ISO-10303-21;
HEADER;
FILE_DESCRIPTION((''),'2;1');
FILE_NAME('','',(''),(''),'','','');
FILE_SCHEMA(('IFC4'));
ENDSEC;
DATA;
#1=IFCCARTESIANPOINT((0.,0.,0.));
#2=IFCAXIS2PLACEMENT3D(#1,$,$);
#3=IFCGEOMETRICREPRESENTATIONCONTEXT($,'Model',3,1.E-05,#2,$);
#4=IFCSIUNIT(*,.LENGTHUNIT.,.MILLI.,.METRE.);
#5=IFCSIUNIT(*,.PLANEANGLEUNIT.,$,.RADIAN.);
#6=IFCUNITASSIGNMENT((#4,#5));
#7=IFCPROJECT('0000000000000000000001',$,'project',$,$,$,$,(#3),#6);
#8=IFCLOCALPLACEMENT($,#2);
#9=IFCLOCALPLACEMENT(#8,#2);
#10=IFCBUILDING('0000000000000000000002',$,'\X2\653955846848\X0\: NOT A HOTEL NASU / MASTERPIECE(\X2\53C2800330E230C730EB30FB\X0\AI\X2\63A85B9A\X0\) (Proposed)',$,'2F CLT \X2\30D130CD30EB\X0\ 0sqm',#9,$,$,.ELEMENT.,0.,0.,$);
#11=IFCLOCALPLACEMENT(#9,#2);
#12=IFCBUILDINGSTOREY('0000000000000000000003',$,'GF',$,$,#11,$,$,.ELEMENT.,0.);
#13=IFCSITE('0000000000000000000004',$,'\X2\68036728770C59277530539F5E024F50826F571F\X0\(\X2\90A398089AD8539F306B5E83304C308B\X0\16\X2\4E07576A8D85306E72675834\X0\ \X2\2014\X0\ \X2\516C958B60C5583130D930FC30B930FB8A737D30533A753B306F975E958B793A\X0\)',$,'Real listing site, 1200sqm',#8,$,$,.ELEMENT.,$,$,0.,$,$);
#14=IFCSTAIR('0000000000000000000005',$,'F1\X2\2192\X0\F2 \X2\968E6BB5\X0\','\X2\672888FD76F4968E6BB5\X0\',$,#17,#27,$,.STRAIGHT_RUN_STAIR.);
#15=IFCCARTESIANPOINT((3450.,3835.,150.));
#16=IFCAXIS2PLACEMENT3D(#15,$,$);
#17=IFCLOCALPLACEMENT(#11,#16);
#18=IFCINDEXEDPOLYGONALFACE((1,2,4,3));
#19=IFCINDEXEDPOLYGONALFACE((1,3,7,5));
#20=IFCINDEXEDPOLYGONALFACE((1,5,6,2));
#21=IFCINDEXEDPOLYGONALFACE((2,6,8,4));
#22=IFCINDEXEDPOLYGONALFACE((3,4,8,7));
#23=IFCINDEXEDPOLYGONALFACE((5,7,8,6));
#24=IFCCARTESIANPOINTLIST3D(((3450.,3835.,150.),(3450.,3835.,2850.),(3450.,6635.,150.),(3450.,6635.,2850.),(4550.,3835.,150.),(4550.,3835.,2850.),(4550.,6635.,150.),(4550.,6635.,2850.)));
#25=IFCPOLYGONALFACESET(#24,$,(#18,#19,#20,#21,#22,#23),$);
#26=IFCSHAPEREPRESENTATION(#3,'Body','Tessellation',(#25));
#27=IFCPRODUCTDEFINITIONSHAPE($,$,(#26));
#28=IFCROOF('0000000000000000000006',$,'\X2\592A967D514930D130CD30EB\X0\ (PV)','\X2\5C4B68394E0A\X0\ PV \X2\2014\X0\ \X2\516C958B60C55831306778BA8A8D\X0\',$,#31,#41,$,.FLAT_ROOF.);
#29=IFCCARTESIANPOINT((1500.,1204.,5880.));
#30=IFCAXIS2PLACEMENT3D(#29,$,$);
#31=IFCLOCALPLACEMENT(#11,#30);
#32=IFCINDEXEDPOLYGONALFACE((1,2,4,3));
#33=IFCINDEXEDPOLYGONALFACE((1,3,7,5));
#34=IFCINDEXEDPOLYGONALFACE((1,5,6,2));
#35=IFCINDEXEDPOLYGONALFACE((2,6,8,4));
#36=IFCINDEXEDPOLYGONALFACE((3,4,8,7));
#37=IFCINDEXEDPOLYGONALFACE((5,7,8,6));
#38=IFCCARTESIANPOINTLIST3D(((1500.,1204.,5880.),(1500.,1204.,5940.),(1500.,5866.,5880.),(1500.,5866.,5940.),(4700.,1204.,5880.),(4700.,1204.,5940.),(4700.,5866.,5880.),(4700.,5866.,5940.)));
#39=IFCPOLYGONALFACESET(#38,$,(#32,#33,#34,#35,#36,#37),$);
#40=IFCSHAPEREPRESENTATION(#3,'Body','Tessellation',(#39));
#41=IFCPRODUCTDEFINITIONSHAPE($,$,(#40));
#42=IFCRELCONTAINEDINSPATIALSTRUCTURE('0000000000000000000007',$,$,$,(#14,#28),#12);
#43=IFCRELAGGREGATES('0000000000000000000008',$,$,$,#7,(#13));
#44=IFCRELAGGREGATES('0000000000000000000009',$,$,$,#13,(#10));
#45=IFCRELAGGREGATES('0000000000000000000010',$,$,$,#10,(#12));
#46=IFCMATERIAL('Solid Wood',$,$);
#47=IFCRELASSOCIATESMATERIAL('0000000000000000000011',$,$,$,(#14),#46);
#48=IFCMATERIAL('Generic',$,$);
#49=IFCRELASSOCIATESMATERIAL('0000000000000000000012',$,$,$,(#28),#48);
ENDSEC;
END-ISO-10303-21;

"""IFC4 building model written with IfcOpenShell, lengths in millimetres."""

from ifc_helpers import new_model, si_unit, frame, frame_2d, origin, place, context, project, spatial, rectangle, extrude, material, element, save


model = new_model("IFC4")

# Units and contexts
model_context = context("Model", 3, precision=1e-05, world=origin())
ifc_project = project(units=[si_unit("LENGTHUNIT", "METRE", prefix="MILLI"), si_unit("PLANEANGLEUNIT", "RADIAN")], contexts=[model_context])

# Site, building, storey
site_placement = place(None, origin())
site = spatial("IfcSite", under=ifc_project, at=site_placement, Name="栃木県大田原市佐良土(那須高原に広がる16万坪超の牧場 — 公開情報ベース・詳細区画は非開示)", ObjectType="Real listing site, 1200sqm", CompositionType="ELEMENT", RefElevation=0.0)
building_placement = place(site_placement, origin())
building = spatial("IfcBuilding", under=site, at=building_placement, Name="改善案: NOT A HOTEL NASU / MASTERPIECE(参考モデル・AI推定) (Proposed)", ObjectType="2F CLT パネル 0sqm", CompositionType="ELEMENT", ElevationOfRefHeight=0.0, ElevationOfTerrain=0.0)
storey_placement = place(building_placement, origin())
storey = spatial("IfcBuildingStorey", under=building, at=storey_placement, Name="GF", CompositionType="ELEMENT", Elevation=0.0)

# Shared definitions
ifc_material_1 = material(Name="Generic")

# Stair
ifc_material_2 = material(Name="Solid Wood")
stair_placement = place(storey_placement, frame((3450.0, 3835.0, 150.0)))
element("IfcStair", 1, at=stair_placement, inside=storey, material=ifc_material_2, Name="F1→F2 階段", Description="木製直階段", PredefinedType="STRAIGHT_RUN_STAIR", context=model_context, shape_type="SweptSolid", body=[
    extrude(rectangle(XDim=1100.0, YDim=2800.0, at=frame_2d((550.0, 1400.0))), frame((3450.0, 3835.0, 150.0)), (0.0, 0.0, 1.0), 2700.0),
])

# Roof
roof_placement = place(storey_placement, frame((1500.0, 1204.0, 5880.0)))
element("IfcRoof", 2, at=roof_placement, inside=storey, material=ifc_material_1, Name="太陽光パネル (PV)", Description="屋根上 PV — 公開情報で確認", PredefinedType="FLAT_ROOF", context=model_context, shape_type="SweptSolid", body=[
    extrude(rectangle(XDim=3200.0, YDim=4662.0, at=frame_2d((1600.0, 2331.0))), frame((1500.0, 1204.0, 5880.0)), (0.0, 0.0, 1.0), 60.0),
])

save(model, "model.ifc")
